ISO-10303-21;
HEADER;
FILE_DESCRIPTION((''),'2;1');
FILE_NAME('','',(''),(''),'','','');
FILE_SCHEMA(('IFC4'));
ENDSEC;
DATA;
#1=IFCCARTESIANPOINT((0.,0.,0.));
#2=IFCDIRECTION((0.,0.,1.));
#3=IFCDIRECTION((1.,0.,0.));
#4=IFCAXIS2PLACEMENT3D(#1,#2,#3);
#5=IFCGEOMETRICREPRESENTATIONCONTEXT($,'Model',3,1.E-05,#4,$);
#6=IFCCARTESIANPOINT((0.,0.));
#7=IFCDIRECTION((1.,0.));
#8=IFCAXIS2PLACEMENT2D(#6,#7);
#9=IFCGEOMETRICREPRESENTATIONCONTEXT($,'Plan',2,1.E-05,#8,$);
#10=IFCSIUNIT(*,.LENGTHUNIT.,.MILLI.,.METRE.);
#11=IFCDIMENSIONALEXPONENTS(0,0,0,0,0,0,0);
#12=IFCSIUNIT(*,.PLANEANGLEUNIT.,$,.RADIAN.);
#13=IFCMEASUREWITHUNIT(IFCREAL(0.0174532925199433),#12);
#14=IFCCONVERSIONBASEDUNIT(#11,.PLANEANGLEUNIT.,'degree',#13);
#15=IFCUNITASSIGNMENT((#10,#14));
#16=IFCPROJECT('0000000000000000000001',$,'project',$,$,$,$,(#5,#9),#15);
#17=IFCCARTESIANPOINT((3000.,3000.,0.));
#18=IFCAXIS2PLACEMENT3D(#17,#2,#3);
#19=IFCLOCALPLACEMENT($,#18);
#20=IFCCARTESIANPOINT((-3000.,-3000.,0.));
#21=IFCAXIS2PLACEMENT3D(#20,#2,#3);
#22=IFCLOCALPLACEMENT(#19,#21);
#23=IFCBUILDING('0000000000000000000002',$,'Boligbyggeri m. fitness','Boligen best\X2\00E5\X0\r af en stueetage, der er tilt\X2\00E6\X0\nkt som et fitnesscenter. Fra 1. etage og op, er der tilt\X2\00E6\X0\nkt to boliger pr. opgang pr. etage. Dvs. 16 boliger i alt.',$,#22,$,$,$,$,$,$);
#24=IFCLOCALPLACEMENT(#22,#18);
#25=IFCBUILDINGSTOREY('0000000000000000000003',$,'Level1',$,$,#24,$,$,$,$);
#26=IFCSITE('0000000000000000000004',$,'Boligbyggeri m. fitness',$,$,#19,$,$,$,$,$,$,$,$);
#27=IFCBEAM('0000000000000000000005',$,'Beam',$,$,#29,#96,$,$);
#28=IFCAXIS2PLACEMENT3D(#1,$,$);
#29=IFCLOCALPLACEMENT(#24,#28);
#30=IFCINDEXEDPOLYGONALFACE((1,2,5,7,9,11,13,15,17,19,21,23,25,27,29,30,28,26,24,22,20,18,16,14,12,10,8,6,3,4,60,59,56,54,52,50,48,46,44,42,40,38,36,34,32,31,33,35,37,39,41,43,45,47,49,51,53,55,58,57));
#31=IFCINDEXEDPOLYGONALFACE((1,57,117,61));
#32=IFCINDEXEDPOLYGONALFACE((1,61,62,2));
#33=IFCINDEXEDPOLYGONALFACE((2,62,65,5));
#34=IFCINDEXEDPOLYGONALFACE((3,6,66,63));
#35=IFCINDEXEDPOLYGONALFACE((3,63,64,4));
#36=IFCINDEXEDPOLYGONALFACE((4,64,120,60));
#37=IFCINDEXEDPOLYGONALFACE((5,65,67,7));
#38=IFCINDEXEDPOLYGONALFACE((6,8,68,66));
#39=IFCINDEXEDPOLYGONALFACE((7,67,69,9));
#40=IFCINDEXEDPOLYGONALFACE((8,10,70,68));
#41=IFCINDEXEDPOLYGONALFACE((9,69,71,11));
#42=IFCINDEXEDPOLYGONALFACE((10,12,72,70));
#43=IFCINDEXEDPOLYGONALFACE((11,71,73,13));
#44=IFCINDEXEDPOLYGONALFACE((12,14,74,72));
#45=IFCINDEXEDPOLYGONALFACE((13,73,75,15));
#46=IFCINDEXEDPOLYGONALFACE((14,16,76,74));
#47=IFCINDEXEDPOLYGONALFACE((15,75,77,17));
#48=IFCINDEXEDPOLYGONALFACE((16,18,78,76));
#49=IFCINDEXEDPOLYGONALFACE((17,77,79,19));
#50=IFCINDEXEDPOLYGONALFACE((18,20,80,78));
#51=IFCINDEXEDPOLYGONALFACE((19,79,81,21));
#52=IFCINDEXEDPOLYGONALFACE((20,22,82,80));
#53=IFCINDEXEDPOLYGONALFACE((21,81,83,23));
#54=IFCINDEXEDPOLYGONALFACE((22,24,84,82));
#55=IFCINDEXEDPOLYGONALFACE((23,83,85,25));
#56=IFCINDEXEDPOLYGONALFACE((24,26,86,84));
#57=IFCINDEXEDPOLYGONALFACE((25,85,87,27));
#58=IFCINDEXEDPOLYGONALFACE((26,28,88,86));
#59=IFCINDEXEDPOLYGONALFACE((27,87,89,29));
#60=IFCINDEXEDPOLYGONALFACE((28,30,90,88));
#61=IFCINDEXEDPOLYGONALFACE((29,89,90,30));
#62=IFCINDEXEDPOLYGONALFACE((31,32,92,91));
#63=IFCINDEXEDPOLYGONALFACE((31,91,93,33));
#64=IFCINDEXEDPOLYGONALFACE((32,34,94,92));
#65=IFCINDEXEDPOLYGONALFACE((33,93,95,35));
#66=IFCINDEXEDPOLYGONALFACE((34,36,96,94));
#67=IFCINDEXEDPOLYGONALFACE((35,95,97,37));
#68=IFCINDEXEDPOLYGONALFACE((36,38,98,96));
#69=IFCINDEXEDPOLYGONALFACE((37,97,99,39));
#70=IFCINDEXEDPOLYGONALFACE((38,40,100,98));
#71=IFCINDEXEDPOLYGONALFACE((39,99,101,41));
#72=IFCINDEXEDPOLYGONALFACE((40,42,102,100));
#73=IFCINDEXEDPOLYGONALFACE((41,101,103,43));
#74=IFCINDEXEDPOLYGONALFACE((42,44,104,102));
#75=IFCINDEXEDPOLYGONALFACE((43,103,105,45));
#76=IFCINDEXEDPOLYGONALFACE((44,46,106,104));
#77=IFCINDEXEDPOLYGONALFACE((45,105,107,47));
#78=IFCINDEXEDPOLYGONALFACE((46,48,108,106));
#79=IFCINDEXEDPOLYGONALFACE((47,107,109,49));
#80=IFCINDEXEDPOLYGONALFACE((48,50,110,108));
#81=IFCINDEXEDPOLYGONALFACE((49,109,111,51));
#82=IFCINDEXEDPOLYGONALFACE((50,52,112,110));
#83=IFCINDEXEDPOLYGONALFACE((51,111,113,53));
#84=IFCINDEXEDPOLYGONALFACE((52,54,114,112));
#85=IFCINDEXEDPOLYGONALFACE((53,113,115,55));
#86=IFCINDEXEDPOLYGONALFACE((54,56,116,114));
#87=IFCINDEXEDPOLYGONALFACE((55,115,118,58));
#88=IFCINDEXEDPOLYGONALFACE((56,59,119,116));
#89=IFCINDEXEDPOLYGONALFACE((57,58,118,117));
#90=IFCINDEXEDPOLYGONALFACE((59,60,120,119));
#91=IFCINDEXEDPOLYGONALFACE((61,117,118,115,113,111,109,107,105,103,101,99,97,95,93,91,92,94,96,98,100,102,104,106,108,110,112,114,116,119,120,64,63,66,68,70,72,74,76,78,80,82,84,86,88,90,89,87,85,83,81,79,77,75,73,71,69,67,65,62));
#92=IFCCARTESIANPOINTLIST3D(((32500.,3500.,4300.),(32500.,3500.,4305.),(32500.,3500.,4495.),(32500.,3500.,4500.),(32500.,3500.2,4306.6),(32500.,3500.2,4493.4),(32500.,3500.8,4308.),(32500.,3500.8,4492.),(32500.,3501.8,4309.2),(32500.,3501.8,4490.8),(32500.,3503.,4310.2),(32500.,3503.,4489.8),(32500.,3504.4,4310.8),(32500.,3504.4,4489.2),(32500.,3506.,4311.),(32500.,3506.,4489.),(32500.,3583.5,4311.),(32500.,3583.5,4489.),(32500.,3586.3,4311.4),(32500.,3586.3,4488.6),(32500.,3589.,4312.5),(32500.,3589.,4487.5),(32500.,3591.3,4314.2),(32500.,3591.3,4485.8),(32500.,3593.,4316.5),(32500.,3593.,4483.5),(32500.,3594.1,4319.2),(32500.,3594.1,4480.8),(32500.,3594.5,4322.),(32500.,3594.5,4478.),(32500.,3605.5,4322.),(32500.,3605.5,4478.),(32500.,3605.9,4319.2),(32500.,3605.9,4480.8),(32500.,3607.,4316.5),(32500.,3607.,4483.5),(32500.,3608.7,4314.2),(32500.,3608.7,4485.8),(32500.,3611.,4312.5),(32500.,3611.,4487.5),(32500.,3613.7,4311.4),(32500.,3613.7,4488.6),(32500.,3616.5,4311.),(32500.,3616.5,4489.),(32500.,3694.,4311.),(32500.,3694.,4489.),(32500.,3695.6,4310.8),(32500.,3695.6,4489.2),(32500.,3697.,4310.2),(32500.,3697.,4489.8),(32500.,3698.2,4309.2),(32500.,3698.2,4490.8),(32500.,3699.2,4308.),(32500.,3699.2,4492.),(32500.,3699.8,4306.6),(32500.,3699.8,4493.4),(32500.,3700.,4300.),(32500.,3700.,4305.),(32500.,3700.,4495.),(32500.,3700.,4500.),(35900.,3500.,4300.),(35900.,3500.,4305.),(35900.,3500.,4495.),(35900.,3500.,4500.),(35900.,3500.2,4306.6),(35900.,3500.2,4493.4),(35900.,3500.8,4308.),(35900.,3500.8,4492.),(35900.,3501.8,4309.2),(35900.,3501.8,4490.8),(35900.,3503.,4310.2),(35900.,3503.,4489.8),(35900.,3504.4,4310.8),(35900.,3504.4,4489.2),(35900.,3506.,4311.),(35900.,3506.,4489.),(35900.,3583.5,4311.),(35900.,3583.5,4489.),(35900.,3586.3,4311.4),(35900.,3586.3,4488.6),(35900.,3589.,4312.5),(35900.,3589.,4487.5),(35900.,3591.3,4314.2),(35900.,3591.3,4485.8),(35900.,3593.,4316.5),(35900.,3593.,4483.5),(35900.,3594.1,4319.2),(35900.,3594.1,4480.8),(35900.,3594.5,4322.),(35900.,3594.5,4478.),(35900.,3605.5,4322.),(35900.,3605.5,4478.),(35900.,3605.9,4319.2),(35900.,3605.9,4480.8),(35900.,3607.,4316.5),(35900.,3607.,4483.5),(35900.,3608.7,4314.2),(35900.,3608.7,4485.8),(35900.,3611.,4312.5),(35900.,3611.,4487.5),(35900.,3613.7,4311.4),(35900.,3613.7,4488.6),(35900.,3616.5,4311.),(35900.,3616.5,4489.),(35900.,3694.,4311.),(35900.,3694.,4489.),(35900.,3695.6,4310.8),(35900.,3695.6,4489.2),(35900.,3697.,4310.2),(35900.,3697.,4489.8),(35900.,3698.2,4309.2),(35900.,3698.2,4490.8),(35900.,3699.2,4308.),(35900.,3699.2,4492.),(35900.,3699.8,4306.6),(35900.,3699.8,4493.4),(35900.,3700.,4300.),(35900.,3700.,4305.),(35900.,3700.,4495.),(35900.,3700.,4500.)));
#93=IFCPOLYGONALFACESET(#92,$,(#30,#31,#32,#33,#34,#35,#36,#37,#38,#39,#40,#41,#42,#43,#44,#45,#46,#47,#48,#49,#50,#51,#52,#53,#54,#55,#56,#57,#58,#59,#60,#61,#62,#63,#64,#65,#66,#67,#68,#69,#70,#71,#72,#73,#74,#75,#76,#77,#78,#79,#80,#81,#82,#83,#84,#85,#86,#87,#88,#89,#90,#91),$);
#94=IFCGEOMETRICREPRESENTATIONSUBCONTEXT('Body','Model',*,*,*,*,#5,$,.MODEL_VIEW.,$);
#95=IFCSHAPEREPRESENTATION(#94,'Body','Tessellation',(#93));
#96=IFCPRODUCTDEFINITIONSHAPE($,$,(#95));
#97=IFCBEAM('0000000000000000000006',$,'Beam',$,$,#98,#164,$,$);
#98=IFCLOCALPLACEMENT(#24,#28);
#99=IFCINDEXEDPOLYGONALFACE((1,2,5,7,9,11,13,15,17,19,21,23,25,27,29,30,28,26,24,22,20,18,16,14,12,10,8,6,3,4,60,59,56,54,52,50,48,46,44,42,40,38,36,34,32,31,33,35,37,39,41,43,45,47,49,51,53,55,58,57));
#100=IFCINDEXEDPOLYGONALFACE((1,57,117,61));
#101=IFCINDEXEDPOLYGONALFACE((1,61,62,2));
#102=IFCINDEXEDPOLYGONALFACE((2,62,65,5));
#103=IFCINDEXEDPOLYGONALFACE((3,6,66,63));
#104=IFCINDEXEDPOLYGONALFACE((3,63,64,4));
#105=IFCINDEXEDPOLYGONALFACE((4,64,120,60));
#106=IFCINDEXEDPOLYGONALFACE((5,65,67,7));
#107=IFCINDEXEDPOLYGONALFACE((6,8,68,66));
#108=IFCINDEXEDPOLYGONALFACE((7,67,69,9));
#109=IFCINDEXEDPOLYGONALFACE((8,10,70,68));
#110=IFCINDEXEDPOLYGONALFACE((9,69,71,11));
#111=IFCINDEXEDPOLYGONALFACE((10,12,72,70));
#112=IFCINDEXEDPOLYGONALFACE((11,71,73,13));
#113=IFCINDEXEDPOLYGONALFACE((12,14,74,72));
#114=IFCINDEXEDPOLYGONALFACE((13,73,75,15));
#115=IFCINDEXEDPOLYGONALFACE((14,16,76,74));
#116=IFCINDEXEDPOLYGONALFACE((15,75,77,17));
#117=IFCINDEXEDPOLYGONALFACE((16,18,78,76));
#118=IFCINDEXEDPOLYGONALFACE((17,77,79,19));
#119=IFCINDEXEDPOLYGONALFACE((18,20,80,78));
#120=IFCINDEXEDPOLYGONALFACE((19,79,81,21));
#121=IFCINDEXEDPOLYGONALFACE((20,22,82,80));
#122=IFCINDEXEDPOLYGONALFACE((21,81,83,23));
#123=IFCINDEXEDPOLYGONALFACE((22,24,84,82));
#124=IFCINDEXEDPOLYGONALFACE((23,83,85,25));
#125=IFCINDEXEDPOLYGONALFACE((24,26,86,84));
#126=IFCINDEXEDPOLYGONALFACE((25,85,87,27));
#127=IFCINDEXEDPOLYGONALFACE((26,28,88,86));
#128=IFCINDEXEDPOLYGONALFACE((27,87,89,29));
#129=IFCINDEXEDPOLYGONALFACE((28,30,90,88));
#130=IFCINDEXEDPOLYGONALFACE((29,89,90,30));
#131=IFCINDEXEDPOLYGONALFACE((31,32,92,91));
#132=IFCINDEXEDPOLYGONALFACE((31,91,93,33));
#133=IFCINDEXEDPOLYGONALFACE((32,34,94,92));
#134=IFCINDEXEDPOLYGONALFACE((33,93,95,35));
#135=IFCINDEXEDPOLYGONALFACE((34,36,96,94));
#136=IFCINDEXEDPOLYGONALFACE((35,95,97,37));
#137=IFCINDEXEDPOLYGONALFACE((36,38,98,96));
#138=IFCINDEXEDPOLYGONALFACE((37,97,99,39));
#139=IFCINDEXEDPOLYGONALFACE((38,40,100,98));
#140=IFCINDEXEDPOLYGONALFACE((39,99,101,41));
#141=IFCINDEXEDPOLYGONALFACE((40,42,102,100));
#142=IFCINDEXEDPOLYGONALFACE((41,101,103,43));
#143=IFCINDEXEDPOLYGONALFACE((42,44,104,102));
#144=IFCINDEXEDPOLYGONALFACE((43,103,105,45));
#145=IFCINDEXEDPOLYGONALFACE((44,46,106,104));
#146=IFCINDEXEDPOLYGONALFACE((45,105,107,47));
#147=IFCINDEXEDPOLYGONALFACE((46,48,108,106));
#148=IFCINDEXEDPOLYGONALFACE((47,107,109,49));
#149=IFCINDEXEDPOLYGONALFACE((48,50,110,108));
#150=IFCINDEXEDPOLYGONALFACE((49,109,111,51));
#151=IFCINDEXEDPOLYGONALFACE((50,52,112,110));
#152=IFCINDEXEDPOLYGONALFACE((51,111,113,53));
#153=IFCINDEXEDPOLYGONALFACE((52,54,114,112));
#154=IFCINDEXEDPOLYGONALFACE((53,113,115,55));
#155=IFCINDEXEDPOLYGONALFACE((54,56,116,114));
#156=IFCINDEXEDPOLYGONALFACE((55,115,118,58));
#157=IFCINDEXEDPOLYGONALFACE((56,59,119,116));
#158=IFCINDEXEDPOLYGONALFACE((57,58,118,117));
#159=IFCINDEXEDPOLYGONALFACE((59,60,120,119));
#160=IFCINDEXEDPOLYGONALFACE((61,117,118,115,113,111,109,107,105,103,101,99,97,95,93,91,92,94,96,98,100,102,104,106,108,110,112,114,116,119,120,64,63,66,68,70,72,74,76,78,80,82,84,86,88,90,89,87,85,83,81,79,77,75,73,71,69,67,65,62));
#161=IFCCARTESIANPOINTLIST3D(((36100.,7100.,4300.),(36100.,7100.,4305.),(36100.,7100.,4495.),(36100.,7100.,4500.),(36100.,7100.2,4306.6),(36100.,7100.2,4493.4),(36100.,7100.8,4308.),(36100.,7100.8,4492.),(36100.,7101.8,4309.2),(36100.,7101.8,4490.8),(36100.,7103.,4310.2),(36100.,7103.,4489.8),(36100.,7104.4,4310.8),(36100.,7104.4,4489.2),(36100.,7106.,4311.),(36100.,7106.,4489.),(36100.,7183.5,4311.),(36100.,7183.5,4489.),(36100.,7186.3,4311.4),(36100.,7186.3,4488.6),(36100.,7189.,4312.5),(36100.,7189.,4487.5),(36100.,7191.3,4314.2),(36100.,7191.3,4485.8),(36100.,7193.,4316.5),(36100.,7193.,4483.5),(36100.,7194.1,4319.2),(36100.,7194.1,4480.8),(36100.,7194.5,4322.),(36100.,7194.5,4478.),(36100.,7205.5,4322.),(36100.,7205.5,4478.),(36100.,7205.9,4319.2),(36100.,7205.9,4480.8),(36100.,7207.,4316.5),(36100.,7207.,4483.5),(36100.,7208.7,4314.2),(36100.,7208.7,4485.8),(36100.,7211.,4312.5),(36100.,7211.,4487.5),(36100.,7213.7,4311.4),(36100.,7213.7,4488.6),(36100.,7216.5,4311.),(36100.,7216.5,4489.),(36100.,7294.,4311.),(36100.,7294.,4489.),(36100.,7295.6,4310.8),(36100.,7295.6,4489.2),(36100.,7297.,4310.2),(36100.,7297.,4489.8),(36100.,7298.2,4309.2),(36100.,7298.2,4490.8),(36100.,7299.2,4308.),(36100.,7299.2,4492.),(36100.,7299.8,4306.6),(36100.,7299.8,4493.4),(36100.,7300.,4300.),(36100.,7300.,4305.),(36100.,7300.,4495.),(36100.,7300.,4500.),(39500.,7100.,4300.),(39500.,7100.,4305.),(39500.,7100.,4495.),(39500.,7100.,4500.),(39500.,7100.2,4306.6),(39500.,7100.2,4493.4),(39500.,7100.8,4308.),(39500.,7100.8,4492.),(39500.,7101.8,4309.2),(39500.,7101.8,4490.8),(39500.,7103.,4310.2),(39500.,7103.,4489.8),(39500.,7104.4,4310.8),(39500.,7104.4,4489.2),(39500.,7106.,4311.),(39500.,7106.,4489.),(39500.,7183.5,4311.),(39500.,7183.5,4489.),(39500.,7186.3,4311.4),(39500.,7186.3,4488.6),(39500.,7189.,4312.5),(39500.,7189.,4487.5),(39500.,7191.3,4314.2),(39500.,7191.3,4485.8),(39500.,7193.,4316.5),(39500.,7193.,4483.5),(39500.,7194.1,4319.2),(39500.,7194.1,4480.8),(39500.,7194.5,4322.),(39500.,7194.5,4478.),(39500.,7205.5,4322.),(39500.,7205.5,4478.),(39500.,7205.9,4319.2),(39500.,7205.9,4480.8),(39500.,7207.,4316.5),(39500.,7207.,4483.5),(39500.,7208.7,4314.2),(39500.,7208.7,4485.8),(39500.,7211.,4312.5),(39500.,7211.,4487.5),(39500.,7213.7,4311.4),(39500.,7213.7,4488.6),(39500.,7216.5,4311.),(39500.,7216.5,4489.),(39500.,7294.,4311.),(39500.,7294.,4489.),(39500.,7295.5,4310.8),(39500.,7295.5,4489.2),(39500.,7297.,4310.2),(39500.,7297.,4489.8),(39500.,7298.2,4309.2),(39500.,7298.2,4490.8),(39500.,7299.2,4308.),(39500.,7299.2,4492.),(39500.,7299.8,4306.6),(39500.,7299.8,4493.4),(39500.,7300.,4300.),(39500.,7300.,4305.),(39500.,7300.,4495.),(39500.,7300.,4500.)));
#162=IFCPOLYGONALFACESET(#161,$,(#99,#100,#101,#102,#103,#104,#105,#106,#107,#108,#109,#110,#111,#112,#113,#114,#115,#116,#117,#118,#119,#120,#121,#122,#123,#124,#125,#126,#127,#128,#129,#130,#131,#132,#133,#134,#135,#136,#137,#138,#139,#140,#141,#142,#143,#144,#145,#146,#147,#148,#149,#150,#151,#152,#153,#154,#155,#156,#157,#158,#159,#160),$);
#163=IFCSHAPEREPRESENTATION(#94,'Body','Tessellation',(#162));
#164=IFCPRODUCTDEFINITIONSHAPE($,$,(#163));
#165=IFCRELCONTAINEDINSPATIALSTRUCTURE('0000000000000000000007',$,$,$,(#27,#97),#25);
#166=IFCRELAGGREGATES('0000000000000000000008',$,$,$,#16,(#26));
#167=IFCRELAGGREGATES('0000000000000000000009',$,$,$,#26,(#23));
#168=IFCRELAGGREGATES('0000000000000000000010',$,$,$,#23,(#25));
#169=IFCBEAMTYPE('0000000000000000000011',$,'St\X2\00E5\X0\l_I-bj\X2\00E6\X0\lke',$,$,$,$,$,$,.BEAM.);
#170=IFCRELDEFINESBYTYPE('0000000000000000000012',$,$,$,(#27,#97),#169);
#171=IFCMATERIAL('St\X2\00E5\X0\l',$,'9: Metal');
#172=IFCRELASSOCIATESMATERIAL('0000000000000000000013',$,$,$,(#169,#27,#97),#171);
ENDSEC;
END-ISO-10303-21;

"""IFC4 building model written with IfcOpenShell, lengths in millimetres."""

from ifc_helpers import new_model, entity, si_unit, converted_unit, frame, origin_with_axes, origin_2d_with_axis, place, context, subcontext, project, spatial, i_section, extrude, material, material_profile, profile_set, profile_usage, type_object, element, save


model = new_model("IFC4")

# Units and contexts
model_context = context("Model", 3, precision=1e-05, world=origin_with_axes())
plan_context = context("Plan", 2, precision=1e-05, world=origin_2d_with_axis())
body_context = subcontext(model_context, "Body", "Model", "MODEL_VIEW")
ifc_project = project(units=[si_unit("LENGTHUNIT", "METRE", prefix="MILLI"), converted_unit("PLANEANGLEUNIT", "degree", entity("IfcReal", 0.0174532925199433), si_unit("PLANEANGLEUNIT", "RADIAN"), dimensions=[0, 0, 0, 0, 0, 0, 0])], contexts=[model_context, plan_context])

# Site, building, storey
site_placement = place(None, frame((3000.0, 3000.0, 0.0), z_axis=(0.0, 0.0, 1.0), x_axis=(1.0, 0.0, 0.0)))
site = spatial("IfcSite", under=ifc_project, at=site_placement, Name="Boligbyggeri m. fitness")
building_placement = place(site_placement, frame((-3000.0, -3000.0, 0.0), z_axis=(0.0, 0.0, 1.0), x_axis=(1.0, 0.0, 0.0)))
building = spatial("IfcBuilding", under=site, at=building_placement, Name="Boligbyggeri m. fitness", Description="Boligen består af en stueetage, der er tiltænkt som et fitnesscenter. Fra 1. etage og op, er der tiltænkt to boliger pr. opgang pr. etage. Dvs. 16 boliger i alt.")
storey_placement = place(building_placement, frame((3000.0, 3000.0, 0.0), z_axis=(0.0, 0.0, 1.0), x_axis=(1.0, 0.0, 0.0)))
storey = spatial("IfcBuildingStorey", under=building, at=storey_placement, Name="Level1")

# Beams
ifc_material_1 = material(Name="Stål", Category="9: Metal")
ifc_material_profile_1 = material_profile(ifc_material_1, i_section(OverallWidth=200.0, OverallDepth=200.0, WebThickness=11.0, FlangeThickness=11.0, FilletRadius=11.0, FlangeEdgeRadius=6.0), Name="Stål", Category="9: Metal")
ifc_profile_set_1 = profile_set([ifc_material_profile_1], Name="NY_I-Profil")
beam_type = type_object("IfcBeamType", Name="Stål_I-bjælke", PredefinedType="BEAM", material=ifc_profile_set_1)
ifc_profile_usage_1 = profile_usage(ifc_profile_set_1, cardinal=7)
beam_1_placement = place(storey_placement, frame((32500.0, 3700.0, 4500.0), z_axis=(1.0, 0.0, 0.0), x_axis=(0.0, 1.0, 0.0)))
element("IfcBeam", 1, at=beam_1_placement, inside=storey, type_object=beam_type, material=ifc_profile_usage_1, Name="Beam", context=body_context, shape_type="SweptSolid", body=[
    extrude(i_section(OverallWidth=200.0, OverallDepth=200.0, WebThickness=11.0, FlangeThickness=11.0, FilletRadius=11.0, FlangeEdgeRadius=6.0), frame((-100.0, -100.0, 0.0), z_axis=(0.0, 0.0, 1.0), x_axis=(1.0, 0.0, 0.0)), (0.0, 0.0, 1.0), 3400.0),
])
ifc_profile_usage_2 = profile_usage(ifc_profile_set_1, cardinal=7)
beam_2_placement = place(storey_placement, frame((36100.0, 7300.0, 4500.0), z_axis=(1.0, 0.0, 0.0), x_axis=(0.0, 1.0, 0.0)))
element("IfcBeam", 2, at=beam_2_placement, inside=storey, type_object=beam_type, material=ifc_profile_usage_2, Name="Beam", context=body_context, shape_type="SweptSolid", body=[
    extrude(i_section(OverallWidth=200.0, OverallDepth=200.0, WebThickness=11.0, FlangeThickness=11.0, FilletRadius=11.0, FlangeEdgeRadius=6.0), frame((-100.0, -100.0, 0.0), z_axis=(0.0, 0.0, 1.0), x_axis=(1.0, 0.0, 0.0)), (0.0, 0.0, 1.0), 3400.0),
])

save(model, "model.ifc")
